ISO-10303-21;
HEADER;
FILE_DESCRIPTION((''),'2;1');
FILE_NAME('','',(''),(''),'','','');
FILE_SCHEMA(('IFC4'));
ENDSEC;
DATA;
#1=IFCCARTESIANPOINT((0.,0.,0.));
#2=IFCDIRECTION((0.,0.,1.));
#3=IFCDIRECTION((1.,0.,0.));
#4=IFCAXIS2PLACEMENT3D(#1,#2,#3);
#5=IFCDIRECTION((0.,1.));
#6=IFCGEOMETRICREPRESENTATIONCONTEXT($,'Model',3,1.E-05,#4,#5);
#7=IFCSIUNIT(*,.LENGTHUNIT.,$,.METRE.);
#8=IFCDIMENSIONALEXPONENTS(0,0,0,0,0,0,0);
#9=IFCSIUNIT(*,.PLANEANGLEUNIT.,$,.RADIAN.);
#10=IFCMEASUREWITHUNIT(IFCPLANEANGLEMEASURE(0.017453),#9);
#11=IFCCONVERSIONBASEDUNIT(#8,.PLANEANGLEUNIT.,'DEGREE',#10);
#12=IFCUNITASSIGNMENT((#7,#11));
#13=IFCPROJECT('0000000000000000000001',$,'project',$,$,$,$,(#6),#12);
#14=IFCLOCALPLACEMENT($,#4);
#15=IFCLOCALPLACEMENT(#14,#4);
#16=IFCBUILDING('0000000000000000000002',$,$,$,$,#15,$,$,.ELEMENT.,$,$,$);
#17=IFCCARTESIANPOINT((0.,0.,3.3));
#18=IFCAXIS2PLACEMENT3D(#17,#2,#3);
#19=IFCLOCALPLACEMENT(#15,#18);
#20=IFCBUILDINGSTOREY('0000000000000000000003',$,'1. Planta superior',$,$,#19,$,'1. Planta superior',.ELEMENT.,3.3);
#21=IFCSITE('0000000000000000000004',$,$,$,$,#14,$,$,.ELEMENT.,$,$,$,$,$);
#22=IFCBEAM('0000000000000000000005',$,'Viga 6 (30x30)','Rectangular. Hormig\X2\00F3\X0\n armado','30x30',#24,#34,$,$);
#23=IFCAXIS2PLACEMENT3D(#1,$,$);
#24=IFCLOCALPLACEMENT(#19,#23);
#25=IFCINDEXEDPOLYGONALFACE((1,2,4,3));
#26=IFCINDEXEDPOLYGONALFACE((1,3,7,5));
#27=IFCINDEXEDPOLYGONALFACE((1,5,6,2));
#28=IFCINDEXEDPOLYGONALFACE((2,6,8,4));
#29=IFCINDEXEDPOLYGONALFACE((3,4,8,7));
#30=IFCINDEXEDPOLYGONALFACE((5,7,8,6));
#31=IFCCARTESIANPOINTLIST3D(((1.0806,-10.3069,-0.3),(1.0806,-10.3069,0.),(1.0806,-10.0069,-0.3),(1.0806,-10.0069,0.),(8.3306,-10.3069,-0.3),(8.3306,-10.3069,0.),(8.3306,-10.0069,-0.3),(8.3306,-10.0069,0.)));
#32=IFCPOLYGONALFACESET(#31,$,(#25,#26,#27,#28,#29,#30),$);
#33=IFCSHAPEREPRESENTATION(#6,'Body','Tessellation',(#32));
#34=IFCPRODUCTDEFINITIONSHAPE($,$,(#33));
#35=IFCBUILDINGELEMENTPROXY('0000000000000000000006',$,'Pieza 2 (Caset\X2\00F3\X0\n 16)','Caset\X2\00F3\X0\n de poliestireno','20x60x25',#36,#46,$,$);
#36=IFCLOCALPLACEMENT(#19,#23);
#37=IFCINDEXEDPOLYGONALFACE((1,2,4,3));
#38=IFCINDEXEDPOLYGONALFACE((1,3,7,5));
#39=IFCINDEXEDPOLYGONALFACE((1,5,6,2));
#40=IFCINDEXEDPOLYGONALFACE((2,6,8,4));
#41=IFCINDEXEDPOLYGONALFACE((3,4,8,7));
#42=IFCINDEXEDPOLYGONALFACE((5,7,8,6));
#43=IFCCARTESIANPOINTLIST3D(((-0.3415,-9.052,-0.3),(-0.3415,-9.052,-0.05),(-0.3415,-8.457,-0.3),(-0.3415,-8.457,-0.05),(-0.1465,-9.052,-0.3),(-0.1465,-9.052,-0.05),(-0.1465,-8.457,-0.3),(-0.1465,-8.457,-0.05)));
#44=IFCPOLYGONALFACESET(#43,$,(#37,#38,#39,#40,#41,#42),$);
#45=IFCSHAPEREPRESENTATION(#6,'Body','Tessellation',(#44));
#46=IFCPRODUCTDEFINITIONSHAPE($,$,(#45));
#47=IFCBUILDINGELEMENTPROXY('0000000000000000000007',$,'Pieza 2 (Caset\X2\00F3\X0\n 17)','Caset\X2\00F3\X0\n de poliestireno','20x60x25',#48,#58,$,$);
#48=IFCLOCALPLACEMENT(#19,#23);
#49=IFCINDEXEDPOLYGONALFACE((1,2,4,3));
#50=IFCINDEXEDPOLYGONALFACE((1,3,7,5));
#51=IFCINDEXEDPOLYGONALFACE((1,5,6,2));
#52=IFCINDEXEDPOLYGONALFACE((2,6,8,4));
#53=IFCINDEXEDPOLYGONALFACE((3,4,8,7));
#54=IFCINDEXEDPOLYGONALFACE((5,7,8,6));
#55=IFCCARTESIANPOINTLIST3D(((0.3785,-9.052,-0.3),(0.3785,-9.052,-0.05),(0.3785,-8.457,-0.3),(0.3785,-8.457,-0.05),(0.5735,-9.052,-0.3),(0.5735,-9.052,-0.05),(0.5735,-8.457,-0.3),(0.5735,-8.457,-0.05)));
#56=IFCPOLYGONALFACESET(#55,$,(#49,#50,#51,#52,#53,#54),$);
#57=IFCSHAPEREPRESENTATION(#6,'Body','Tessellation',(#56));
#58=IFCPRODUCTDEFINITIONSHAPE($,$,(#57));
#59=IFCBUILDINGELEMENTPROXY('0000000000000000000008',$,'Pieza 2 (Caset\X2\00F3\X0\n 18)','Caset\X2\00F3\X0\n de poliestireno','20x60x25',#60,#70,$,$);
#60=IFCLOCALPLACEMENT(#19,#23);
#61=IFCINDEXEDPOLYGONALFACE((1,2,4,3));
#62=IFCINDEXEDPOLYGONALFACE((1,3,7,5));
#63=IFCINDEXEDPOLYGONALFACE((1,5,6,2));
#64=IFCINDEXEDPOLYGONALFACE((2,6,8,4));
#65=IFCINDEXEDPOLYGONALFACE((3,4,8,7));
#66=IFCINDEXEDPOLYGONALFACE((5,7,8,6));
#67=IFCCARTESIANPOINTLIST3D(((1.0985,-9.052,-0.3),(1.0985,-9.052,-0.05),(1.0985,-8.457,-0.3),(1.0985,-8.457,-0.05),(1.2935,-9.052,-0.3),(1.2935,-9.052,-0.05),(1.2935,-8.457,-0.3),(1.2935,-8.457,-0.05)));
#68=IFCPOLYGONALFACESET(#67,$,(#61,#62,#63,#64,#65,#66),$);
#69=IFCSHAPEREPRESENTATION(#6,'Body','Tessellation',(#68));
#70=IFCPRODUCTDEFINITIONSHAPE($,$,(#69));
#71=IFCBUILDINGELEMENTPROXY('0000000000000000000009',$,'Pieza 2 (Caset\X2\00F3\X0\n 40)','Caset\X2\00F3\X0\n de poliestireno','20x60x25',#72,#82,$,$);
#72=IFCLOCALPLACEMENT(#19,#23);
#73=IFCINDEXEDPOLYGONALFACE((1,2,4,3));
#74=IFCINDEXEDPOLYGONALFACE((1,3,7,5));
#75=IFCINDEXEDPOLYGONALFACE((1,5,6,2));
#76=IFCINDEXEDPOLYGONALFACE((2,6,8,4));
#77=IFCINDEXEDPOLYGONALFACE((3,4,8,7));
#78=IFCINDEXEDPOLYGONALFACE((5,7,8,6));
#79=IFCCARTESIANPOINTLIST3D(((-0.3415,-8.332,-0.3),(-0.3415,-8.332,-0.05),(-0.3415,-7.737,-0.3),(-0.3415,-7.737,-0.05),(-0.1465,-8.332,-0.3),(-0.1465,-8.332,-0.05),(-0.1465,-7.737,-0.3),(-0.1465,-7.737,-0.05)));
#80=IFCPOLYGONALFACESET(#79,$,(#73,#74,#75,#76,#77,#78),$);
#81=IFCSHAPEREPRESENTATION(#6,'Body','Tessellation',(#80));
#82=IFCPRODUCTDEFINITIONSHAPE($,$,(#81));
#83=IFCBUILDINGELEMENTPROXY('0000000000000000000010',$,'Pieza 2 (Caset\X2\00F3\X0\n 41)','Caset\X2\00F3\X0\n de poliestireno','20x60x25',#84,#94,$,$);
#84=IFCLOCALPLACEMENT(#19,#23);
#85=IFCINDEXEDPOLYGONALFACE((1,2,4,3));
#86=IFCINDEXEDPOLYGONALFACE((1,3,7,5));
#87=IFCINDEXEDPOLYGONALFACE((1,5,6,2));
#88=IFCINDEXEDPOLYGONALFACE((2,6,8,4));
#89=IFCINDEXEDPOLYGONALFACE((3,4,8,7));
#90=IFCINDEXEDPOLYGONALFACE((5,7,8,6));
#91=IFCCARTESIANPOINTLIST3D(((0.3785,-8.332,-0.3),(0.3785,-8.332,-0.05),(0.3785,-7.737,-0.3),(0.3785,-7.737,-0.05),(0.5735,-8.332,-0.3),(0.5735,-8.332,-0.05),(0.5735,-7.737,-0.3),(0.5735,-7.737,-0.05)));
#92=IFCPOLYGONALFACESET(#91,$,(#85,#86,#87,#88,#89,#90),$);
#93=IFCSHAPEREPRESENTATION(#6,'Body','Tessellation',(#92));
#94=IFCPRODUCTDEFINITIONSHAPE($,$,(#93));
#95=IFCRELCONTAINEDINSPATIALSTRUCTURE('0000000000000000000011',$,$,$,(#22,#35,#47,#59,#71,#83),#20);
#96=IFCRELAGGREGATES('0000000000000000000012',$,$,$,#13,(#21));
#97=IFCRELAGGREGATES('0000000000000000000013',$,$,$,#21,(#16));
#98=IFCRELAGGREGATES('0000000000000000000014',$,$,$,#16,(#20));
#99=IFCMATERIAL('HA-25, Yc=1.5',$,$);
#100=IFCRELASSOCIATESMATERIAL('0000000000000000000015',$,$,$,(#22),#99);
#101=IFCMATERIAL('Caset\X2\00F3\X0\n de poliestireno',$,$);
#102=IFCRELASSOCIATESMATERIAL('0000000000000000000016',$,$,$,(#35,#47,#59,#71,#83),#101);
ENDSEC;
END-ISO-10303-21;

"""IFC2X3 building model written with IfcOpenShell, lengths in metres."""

from ifc_helpers import new_model, entity, si_unit, converted_unit, direction, frame, frame_2d, origin_with_axes, origin_2d_with_axis, place, context, project, spatial, rectangle, extrude, source, transform, mapped, material, element, save


model = new_model("IFC2X3")

# Units and contexts
model_context = context("Model", 3, precision=1e-05, world=origin_with_axes(), true_north=direction((0.0, 1.0)))
ifc_project = project(units=[si_unit("LENGTHUNIT", "METRE"), converted_unit("PLANEANGLEUNIT", "DEGREE", entity("IfcPlaneAngleMeasure", 0.017453), si_unit("PLANEANGLEUNIT", "RADIAN"), dimensions=[0, 0, 0, 0, 0, 0, 0])], contexts=[model_context])

# Site, building, storey
site_placement = place(None, origin_with_axes())
site = spatial("IfcSite", under=ifc_project, at=site_placement, CompositionType="ELEMENT")
building_placement = place(site_placement, origin_with_axes())
building = spatial("IfcBuilding", under=site, at=building_placement, CompositionType="ELEMENT")
storey_placement = place(building_placement, frame((0.0, 0.0, 3.3), z_axis=(0.0, 0.0, 1.0), x_axis=(1.0, 0.0, 0.0)))
storey = spatial("IfcBuildingStorey", under=building, at=storey_placement, Name="1. Planta superior", LongName="1. Planta superior", CompositionType="ELEMENT", Elevation=3.3)

# Beam
ifc_material_1 = material(Name="HA-25, Yc=1.5")
beam_placement = place(storey_placement, frame((1.0806, -10.1569, 0.0), z_axis=(1.0, 0.0, 0.0), x_axis=(0.0, 1.0, 0.0)))
element("IfcBeam", 1, at=beam_placement, inside=storey, material=ifc_material_1, Name="Viga 6 (30x30)", Description="Rectangular. Hormigón armado", ObjectType="30x30", context=model_context, shape_type="SweptSolid", body=[
    extrude(rectangle(XDim=0.3, YDim=0.3, at=frame_2d((0.0, -0.15), x_axis=(1.0, 0.0))), origin_with_axes(), (0.0, 0.0, 1.0), 7.25),
])

# Building element proxies
ifc_material_2 = material(Name="Casetón de poliestireno")
shared_shape = source(origin_with_axes(), model_context, "Body", "SweptSolid", [
    extrude(rectangle(XDim=0.195, YDim=0.25, at=origin_2d_with_axis()), origin_with_axes(), (0.0, 0.0, 1.0), 0.595),
])
placement_1 = place(storey_placement, frame((-0.244, -9.052, -0.175), z_axis=(0.0, 1.0, 0.0), x_axis=(-1.0, 0.0, 0.0)))
for number, where, z_axis, x_axis, name in (
    (2, (0.0, 0.0, 0.0), (0.0, 0.0, 1.0), (1.0, 0.0, 0.0), "Pieza 2 (Casetón 16)"),
):
    element("IfcBuildingElementProxy", number, at=place(placement_1, frame(where, z_axis=z_axis, x_axis=x_axis)), inside=storey, material=ifc_material_2, Name=name, Description="Casetón de poliestireno", ObjectType="20x60x25", context=model_context, shape_type="MappedRepresentation", body=[
        mapped(shared_shape, transform((0.0, 0.0, 0.0), x_axis=(1.0, 0.0, 0.0), y_axis=(0.0, 1.0, 0.0), z_axis=(0.0, 0.0, 1.0))),
    ])
placement_2 = place(storey_placement, frame((0.476, -9.052, -0.175), z_axis=(0.0, 1.0, 0.0), x_axis=(-1.0, 0.0, 0.0)))
for number, where, z_axis, x_axis, name in (
    (3, (0.0, 0.0, 0.0), (0.0, 0.0, 1.0), (1.0, 0.0, 0.0), "Pieza 2 (Casetón 17)"),
):
    element("IfcBuildingElementProxy", number, at=place(placement_2, frame(where, z_axis=z_axis, x_axis=x_axis)), inside=storey, material=ifc_material_2, Name=name, Description="Casetón de poliestireno", ObjectType="20x60x25", context=model_context, shape_type="MappedRepresentation", body=[
        mapped(shared_shape, transform((0.0, 0.0, 0.0), x_axis=(1.0, 0.0, 0.0), y_axis=(0.0, 1.0, 0.0), z_axis=(0.0, 0.0, 1.0))),
    ])
placement_3 = place(storey_placement, frame((1.196, -9.052, -0.175), z_axis=(0.0, 1.0, 0.0), x_axis=(-1.0, 0.0, 0.0)))
for number, where, z_axis, x_axis, name in (
    (4, (0.0, 0.0, 0.0), (0.0, 0.0, 1.0), (1.0, 0.0, 0.0), "Pieza 2 (Casetón 18)"),
):
    element("IfcBuildingElementProxy", number, at=place(placement_3, frame(where, z_axis=z_axis, x_axis=x_axis)), inside=storey, material=ifc_material_2, Name=name, Description="Casetón de poliestireno", ObjectType="20x60x25", context=model_context, shape_type="MappedRepresentation", body=[
        mapped(shared_shape, transform((0.0, 0.0, 0.0), x_axis=(1.0, 0.0, 0.0), y_axis=(0.0, 1.0, 0.0), z_axis=(0.0, 0.0, 1.0))),
    ])
placement_4 = place(storey_placement, frame((-0.244, -8.332, -0.175), z_axis=(0.0, 1.0, 0.0), x_axis=(-1.0, 0.0, 0.0)))
for number, where, z_axis, x_axis, name in (
    (5, (0.0, 0.0, 0.0), (0.0, 0.0, 1.0), (1.0, 0.0, 0.0), "Pieza 2 (Casetón 40)"),
):
    element("IfcBuildingElementProxy", number, at=place(placement_4, frame(where, z_axis=z_axis, x_axis=x_axis)), inside=storey, material=ifc_material_2, Name=name, Description="Casetón de poliestireno", ObjectType="20x60x25", context=model_context, shape_type="MappedRepresentation", body=[
        mapped(shared_shape, transform((0.0, 0.0, 0.0), x_axis=(1.0, 0.0, 0.0), y_axis=(0.0, 1.0, 0.0), z_axis=(0.0, 0.0, 1.0))),
    ])
placement_5 = place(storey_placement, frame((0.476, -8.332, -0.175), z_axis=(0.0, 1.0, 0.0), x_axis=(-1.0, 0.0, 0.0)))
for number, where, z_axis, x_axis, name in (
    (6, (0.0, 0.0, 0.0), (0.0, 0.0, 1.0), (1.0, 0.0, 0.0), "Pieza 2 (Casetón 41)"),
):
    element("IfcBuildingElementProxy", number, at=place(placement_5, frame(where, z_axis=z_axis, x_axis=x_axis)), inside=storey, material=ifc_material_2, Name=name, Description="Casetón de poliestireno", ObjectType="20x60x25", context=model_context, shape_type="MappedRepresentation", body=[
        mapped(shared_shape, transform((0.0, 0.0, 0.0), x_axis=(1.0, 0.0, 0.0), y_axis=(0.0, 1.0, 0.0), z_axis=(0.0, 0.0, 1.0))),
    ])

save(model, "model.ifc")
